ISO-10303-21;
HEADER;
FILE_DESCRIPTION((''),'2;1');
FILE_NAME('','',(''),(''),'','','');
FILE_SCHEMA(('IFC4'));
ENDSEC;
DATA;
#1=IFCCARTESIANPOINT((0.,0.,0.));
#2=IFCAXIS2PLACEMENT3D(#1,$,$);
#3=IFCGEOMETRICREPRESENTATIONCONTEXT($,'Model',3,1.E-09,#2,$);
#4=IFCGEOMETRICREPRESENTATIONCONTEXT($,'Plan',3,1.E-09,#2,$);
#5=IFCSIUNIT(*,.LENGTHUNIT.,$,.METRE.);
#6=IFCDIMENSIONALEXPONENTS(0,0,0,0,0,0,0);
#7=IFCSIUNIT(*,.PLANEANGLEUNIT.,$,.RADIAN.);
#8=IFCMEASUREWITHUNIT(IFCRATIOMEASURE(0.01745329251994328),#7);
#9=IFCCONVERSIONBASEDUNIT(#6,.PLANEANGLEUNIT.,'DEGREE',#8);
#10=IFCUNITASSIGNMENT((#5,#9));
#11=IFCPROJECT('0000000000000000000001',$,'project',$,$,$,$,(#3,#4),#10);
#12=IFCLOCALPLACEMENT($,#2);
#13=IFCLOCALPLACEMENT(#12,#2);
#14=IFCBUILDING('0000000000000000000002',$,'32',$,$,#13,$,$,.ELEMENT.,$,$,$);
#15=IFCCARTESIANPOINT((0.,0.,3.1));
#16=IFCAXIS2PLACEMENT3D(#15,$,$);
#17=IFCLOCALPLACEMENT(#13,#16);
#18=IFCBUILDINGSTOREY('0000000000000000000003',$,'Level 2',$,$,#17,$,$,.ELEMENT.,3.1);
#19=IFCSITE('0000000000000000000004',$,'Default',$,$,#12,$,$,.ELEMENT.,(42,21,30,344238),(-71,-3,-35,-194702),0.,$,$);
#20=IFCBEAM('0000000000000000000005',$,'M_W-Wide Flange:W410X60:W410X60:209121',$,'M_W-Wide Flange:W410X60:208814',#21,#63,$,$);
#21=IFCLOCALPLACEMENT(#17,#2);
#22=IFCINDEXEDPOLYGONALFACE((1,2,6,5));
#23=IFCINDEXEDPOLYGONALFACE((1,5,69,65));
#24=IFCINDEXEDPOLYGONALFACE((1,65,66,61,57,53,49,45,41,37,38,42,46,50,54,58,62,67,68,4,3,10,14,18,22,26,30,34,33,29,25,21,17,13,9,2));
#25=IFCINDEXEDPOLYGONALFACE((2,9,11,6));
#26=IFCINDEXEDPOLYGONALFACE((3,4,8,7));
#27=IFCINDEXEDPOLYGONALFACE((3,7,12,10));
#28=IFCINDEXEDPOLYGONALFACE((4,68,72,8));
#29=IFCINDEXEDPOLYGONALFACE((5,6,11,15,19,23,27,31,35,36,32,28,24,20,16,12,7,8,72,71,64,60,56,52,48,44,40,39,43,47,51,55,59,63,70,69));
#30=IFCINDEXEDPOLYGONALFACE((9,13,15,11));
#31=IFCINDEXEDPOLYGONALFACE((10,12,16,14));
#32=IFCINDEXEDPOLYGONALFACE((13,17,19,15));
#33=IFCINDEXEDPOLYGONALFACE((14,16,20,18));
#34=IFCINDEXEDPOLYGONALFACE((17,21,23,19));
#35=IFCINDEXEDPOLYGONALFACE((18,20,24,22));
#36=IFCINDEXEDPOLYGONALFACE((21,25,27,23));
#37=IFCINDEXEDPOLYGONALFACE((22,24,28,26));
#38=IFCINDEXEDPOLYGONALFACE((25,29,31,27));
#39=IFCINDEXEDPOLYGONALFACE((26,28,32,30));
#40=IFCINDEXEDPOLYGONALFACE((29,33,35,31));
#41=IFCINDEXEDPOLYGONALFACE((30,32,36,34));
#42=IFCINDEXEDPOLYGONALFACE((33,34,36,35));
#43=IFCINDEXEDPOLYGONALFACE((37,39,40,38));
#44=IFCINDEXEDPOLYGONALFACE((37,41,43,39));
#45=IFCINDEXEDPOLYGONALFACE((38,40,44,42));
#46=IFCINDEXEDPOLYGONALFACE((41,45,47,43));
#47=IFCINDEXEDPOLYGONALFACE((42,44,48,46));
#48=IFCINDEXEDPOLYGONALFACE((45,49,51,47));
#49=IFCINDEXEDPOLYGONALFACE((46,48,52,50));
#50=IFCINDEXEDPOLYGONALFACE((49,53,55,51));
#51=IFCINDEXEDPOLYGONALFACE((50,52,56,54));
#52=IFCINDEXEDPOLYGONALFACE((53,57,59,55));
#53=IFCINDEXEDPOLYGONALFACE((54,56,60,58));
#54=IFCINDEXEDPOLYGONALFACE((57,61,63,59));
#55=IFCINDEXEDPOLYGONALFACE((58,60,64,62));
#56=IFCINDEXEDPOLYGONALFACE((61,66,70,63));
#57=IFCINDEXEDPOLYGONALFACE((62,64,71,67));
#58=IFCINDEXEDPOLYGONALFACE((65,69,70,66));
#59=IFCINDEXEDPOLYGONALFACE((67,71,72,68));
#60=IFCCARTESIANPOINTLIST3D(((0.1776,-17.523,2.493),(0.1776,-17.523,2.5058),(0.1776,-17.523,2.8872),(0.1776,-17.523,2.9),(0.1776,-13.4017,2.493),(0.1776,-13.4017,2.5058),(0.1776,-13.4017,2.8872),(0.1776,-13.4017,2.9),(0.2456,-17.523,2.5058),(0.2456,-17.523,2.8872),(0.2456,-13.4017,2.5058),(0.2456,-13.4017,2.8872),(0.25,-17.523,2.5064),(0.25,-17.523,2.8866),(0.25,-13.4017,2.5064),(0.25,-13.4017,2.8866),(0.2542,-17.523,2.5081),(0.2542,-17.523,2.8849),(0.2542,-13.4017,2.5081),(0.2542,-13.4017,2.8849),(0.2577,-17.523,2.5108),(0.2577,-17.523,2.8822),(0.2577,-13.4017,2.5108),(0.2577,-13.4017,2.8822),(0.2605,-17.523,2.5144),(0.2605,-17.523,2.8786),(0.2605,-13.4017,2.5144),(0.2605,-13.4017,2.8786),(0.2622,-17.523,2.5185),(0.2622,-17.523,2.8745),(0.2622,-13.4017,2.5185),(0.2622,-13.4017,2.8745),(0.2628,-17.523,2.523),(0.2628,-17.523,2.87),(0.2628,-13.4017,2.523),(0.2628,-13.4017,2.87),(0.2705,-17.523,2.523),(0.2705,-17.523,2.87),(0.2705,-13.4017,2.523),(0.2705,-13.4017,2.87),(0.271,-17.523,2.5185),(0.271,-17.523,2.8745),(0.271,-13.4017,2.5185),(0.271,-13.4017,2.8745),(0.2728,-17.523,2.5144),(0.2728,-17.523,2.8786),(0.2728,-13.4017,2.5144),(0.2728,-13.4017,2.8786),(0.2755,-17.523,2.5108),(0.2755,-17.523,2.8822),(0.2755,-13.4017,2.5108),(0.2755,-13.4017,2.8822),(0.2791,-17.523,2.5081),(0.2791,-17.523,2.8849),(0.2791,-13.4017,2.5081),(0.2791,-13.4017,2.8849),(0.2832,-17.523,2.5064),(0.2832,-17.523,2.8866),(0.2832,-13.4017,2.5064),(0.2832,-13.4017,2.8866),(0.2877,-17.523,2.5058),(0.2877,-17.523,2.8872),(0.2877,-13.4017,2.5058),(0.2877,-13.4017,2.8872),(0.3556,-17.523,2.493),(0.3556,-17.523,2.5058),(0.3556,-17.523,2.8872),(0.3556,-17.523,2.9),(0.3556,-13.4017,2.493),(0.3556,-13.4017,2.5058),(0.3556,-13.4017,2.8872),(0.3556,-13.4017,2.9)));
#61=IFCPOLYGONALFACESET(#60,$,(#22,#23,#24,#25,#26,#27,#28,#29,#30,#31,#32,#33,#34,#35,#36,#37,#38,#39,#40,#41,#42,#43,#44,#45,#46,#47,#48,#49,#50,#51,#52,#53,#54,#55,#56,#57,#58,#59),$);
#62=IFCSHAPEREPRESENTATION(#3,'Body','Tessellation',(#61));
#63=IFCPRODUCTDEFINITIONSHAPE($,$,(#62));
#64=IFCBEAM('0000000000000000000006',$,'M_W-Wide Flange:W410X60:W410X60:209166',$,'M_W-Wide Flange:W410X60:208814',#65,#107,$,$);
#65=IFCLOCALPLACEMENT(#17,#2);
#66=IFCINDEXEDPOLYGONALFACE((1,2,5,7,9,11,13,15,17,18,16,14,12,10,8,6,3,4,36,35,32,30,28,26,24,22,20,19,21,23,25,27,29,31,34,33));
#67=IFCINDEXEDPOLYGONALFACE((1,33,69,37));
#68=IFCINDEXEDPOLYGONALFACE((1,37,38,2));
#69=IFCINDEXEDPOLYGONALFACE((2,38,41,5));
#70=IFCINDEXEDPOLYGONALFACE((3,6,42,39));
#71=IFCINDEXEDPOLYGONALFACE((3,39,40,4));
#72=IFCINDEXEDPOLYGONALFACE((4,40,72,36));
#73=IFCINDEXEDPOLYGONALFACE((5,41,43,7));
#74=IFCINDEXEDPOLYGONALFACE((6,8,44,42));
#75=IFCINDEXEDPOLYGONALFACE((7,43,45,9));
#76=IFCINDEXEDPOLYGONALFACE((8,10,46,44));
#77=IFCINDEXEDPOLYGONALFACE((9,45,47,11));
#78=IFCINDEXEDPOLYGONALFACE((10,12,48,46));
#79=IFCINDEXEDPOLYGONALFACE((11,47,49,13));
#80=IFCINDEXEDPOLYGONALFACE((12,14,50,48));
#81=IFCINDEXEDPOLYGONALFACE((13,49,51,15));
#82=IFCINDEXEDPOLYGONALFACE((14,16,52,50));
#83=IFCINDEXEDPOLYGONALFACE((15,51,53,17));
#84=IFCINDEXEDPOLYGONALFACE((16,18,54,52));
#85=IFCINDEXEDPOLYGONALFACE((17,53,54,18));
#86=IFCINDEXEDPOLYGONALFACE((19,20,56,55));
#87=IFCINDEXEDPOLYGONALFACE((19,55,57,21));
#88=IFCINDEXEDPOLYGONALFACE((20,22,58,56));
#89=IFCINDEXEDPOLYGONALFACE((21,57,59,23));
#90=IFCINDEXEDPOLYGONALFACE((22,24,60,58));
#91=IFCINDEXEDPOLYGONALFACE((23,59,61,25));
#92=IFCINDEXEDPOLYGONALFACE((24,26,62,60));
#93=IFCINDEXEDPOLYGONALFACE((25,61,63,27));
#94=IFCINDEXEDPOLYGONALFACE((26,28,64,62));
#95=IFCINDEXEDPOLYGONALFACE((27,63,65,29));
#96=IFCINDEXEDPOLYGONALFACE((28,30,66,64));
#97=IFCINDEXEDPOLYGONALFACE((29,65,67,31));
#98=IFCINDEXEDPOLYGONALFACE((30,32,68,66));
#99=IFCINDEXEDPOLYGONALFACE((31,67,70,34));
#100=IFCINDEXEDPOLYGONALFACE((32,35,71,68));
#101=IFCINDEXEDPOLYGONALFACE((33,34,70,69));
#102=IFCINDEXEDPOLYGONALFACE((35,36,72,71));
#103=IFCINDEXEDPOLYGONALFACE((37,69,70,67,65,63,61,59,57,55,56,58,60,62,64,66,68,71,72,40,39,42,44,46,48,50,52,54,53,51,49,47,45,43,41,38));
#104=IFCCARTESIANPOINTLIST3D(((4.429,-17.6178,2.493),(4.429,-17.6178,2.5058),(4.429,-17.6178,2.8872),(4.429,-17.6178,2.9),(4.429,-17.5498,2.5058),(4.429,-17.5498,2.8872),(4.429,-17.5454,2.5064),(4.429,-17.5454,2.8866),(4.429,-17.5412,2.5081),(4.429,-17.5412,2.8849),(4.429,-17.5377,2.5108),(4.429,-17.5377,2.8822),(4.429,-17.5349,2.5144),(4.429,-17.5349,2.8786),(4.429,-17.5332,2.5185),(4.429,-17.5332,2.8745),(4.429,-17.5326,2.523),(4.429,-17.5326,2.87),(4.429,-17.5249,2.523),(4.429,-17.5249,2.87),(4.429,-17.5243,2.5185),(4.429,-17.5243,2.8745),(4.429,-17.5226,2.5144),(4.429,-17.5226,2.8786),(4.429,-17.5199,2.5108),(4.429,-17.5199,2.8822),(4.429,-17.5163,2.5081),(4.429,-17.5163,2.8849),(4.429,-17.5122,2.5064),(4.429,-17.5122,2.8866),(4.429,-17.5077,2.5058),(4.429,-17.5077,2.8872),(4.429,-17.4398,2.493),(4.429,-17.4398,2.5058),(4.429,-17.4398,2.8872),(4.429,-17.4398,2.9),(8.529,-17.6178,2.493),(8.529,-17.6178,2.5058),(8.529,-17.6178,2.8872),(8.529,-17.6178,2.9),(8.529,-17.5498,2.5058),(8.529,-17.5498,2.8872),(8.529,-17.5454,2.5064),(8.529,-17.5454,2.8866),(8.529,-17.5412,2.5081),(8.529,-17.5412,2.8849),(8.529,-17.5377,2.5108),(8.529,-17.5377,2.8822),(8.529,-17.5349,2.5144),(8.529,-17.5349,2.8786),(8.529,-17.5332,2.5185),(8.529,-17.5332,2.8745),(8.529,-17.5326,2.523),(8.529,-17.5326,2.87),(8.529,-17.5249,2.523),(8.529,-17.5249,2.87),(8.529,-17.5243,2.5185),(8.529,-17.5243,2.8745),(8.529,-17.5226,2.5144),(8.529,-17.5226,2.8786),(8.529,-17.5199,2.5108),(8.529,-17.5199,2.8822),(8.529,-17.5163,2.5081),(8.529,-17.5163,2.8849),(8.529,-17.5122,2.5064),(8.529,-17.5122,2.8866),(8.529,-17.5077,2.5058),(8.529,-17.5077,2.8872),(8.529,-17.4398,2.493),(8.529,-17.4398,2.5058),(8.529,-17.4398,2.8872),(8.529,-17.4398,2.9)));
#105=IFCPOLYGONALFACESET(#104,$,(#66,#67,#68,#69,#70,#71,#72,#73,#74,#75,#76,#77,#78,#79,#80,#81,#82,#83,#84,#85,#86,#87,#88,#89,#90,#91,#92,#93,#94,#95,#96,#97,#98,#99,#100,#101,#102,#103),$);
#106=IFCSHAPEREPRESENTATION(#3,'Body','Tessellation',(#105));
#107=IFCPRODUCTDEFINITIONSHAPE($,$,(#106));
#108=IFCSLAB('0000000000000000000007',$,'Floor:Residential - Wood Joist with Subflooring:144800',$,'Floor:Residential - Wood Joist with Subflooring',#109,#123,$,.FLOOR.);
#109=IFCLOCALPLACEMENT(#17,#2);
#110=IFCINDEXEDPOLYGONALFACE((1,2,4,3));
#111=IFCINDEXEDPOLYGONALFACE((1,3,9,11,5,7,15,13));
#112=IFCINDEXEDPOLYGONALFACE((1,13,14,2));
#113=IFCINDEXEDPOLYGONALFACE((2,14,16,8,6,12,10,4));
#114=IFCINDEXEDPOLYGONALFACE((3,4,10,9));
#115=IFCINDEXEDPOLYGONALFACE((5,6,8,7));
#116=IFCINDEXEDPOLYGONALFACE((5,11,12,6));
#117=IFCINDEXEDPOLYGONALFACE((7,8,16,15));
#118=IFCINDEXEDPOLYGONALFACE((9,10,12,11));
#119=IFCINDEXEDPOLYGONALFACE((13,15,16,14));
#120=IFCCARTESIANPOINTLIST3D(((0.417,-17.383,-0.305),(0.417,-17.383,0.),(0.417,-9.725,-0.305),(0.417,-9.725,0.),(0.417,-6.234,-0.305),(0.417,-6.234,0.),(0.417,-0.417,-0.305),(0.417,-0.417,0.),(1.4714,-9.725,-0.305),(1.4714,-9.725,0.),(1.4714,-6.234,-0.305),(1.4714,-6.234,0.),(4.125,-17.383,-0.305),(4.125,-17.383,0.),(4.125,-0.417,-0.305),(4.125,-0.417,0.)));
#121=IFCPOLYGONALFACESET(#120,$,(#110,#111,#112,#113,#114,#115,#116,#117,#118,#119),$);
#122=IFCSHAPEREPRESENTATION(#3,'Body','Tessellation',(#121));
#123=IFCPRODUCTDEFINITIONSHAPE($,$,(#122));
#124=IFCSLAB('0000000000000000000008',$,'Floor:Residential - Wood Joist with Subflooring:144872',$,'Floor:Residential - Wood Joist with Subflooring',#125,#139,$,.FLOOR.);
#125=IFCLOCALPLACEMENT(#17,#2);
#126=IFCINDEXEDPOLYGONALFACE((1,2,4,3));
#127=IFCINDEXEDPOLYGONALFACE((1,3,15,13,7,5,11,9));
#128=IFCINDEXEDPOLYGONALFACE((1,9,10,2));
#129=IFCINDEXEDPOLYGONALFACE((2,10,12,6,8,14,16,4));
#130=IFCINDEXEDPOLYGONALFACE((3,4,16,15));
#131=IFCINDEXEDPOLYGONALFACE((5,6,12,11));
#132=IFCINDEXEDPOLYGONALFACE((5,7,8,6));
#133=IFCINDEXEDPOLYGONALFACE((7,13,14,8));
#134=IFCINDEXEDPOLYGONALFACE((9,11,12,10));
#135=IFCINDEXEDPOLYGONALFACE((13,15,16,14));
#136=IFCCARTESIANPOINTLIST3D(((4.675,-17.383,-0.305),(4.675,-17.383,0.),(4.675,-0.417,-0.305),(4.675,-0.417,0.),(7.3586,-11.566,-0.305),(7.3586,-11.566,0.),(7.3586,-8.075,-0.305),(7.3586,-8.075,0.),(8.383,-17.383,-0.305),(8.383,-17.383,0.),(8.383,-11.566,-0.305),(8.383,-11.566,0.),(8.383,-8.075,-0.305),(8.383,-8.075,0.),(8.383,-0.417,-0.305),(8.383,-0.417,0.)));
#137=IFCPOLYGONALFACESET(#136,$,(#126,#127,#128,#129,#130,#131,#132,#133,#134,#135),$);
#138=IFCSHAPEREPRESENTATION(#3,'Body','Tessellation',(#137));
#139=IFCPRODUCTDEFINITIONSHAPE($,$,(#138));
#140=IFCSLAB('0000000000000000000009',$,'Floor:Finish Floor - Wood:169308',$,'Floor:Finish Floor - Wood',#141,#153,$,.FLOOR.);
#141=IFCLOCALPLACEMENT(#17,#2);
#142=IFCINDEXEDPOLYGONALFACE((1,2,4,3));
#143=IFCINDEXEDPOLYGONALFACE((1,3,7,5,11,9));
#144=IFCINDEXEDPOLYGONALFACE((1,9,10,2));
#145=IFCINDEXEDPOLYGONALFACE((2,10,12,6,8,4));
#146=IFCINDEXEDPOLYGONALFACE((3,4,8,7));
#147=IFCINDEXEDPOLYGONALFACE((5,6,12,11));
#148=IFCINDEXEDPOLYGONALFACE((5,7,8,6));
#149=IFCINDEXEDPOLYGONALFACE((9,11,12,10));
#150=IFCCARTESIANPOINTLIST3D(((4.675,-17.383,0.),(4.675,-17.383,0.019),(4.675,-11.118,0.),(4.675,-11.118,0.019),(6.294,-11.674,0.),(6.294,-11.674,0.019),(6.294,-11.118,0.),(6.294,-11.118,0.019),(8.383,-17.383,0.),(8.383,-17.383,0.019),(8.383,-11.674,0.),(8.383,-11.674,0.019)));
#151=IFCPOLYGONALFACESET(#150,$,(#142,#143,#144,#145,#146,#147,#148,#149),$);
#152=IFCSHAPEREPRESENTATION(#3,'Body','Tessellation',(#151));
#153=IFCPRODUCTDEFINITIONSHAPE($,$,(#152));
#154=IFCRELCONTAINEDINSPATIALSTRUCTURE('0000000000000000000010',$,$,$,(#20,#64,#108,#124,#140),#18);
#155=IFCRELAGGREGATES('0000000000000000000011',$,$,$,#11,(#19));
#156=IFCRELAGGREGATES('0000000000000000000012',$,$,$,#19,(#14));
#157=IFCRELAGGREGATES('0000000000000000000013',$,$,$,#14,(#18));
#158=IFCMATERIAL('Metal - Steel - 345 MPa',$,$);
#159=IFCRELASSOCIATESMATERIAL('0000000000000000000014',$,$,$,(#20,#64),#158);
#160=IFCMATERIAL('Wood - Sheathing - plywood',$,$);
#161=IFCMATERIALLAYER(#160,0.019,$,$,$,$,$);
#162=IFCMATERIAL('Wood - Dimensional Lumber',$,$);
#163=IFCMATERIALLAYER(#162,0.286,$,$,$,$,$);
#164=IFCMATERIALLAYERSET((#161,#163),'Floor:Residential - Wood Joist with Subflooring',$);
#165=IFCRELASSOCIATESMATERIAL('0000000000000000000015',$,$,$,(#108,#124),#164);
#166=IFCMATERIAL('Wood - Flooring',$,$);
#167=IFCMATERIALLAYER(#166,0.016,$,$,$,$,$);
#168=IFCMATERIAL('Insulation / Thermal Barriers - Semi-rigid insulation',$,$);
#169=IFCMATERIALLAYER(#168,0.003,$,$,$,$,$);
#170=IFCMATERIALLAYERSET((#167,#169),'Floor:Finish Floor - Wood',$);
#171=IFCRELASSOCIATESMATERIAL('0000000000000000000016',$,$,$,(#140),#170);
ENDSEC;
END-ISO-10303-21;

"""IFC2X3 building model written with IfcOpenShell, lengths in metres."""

from ifc_helpers import new_model, entity, si_unit, converted_unit, frame, frame_2d, origin, place, context, project, spatial, polyline, circle_curve, parameter, trimmed, segment, composite_curve, outline, extrude, material, layer, layer_set, layer_usage, element, save


model = new_model("IFC2X3")

# Units and contexts
model_context = context("Model", 3, precision=1e-09, world=origin())
plan_context = context("Plan", 3, precision=1e-09, world=origin())
ifc_project = project(units=[si_unit("LENGTHUNIT", "METRE"), converted_unit("PLANEANGLEUNIT", "DEGREE", entity("IfcRatioMeasure", 0.01745329251994328), si_unit("PLANEANGLEUNIT", "RADIAN"), dimensions=[0, 0, 0, 0, 0, 0, 0])], contexts=[model_context, plan_context])

# Site, building, storey
site_placement = place(None, origin())
site = spatial("IfcSite", under=ifc_project, at=site_placement, Name="Default", CompositionType="ELEMENT", RefLatitude=(42, 21, 30, 344238), RefLongitude=(-71, -3, -35, -194702), RefElevation=0.0)
building_placement = place(site_placement, origin())
building = spatial("IfcBuilding", under=site, at=building_placement, Name="32", CompositionType="ELEMENT")
storey_placement = place(building_placement, frame((0.0, 0.0, 3.1)))
storey = spatial("IfcBuildingStorey", under=building, at=storey_placement, Name="Level 2", CompositionType="ELEMENT", Elevation=3.1)

# Beams
ifc_material_1 = material(Name="Metal - Steel - 345 MPa")
beam_1_placement = place(storey_placement, frame((0.2666, -13.4017, 2.9), z_axis=(0.0, 0.0, 1.0), x_axis=(-1.0, 0.0, 0.0)))
element("IfcBeam", 1, at=beam_1_placement, inside=storey, material=ifc_material_1, Name="M_W-Wide Flange:W410X60:W410X60:209121", ObjectType="M_W-Wide Flange:W410X60:208814", context=model_context, shape_type="SweptSolid", body=[
    extrude(outline(composite_curve([segment(polyline([(0.1907, -0.089), (0.2035, -0.089)]), True, "CONTINUOUS"), segment(polyline([(0.2035, -0.089), (0.2035, 0.089)]), True, "CONTINUOUS"), segment(polyline([(0.2035, 0.089), (0.1907, 0.089)]), True, "CONTINUOUS"), segment(polyline([(0.1907, 0.089), (0.1907, 0.021)]), True, "CONTINUOUS"), segment(trimmed(circle_curve(frame_2d((0.1735, 0.021), x_axis=(1.0, 0.0)), 0.0172), [parameter(270.0)], [parameter(360.0)], True, "PARAMETER"), False, "CONTINUOUS"), segment(polyline([(0.1735, 0.0038), (-0.1735, 0.0038)]), True, "CONTINUOUS"), segment(trimmed(circle_curve(frame_2d((-0.1735, 0.021), x_axis=(0.0, -1.0)), 0.0172), [parameter(270.0)], [parameter(360.0)], True, "PARAMETER"), False, "CONTINUOUS"), segment(polyline([(-0.1907, 0.021), (-0.1907, 0.089)]), True, "CONTINUOUS"), segment(polyline([(-0.1907, 0.089), (-0.2035, 0.089)]), True, "CONTINUOUS"), segment(polyline([(-0.2035, 0.089), (-0.2035, -0.089)]), True, "CONTINUOUS"), segment(polyline([(-0.2035, -0.089), (-0.1907, -0.089)]), True, "CONTINUOUS"), segment(polyline([(-0.1907, -0.089), (-0.1907, -0.0211)]), True, "CONTINUOUS"), segment(trimmed(circle_curve(frame_2d((-0.1735, -0.0211), x_axis=(-1.0, 0.0)), 0.0172), [parameter(270.0)], [parameter(0.0)], True, "PARAMETER"), False, "CONTINUOUS"), segment(polyline([(-0.1735, -0.0039), (0.1735, -0.0039)]), True, "CONTINUOUS"), segment(trimmed(circle_curve(frame_2d((0.1735, -0.0211), x_axis=(0.0, 1.0)), 0.0172), [parameter(270.0)], [parameter(0.0)], True, "PARAMETER"), False, "CONTINUOUS"), segment(polyline([(0.1907, -0.0211), (0.1907, -0.089)]), True, "CONTINUOUS")], self_intersect=False)), frame((0.0, 4.1213, -0.2035), z_axis=(0.0, -1.0, 0.0), x_axis=(0.0, 0.0, -1.0)), (0.0, 0.0, 1.0), 4.1213),
])
beam_2_placement = place(storey_placement, frame((4.429, -17.5288, 2.9), z_axis=(0.0, 0.0, 1.0), x_axis=(0.0, -1.0, 0.0)))
element("IfcBeam", 2, at=beam_2_placement, inside=storey, material=ifc_material_1, Name="M_W-Wide Flange:W410X60:W410X60:209166", ObjectType="M_W-Wide Flange:W410X60:208814", context=model_context, shape_type="SweptSolid", body=[
    extrude(outline(composite_curve([segment(polyline([(-0.089, -0.1907), (-0.089, -0.2035)]), True, "CONTINUOUS"), segment(polyline([(-0.089, -0.2035), (0.089, -0.2035)]), True, "CONTINUOUS"), segment(polyline([(0.089, -0.2035), (0.089, -0.1907)]), True, "CONTINUOUS"), segment(polyline([(0.089, -0.1907), (0.021, -0.1907)]), True, "CONTINUOUS"), segment(trimmed(circle_curve(frame_2d((0.021, -0.1735), x_axis=(0.0, -1.0)), 0.0172), [parameter(270.0)], [parameter(360.0)], True, "PARAMETER"), False, "CONTINUOUS"), segment(polyline([(0.0038, -0.1735), (0.0038, 0.1735)]), True, "CONTINUOUS"), segment(trimmed(circle_curve(frame_2d((0.021, 0.1735), x_axis=(-1.0, 0.0)), 0.0172), [parameter(270.0)], [parameter(360.0)], True, "PARAMETER"), False, "CONTINUOUS"), segment(polyline([(0.021, 0.1907), (0.089, 0.1907)]), True, "CONTINUOUS"), segment(polyline([(0.089, 0.1907), (0.089, 0.2035)]), True, "CONTINUOUS"), segment(polyline([(0.089, 0.2035), (-0.089, 0.2035)]), True, "CONTINUOUS"), segment(polyline([(-0.089, 0.2035), (-0.089, 0.1907)]), True, "CONTINUOUS"), segment(polyline([(-0.089, 0.1907), (-0.0211, 0.1907)]), True, "CONTINUOUS"), segment(trimmed(circle_curve(frame_2d((-0.0211, 0.1735), x_axis=(0.0, 1.0)), 0.0172), [parameter(270.0)], [parameter(0.0)], True, "PARAMETER"), False, "CONTINUOUS"), segment(polyline([(-0.0039, 0.1735), (-0.0039, -0.1735)]), True, "CONTINUOUS"), segment(trimmed(circle_curve(frame_2d((-0.0211, -0.1735), x_axis=(1.0, 0.0)), 0.0172), [parameter(270.0)], [parameter(0.0)], True, "PARAMETER"), False, "CONTINUOUS"), segment(polyline([(-0.0211, -0.1907), (-0.089, -0.1907)]), True, "CONTINUOUS")], self_intersect=False)), frame((0.0, 0.0, -0.2035), z_axis=(0.0, -1.0, 0.0), x_axis=(1.0, 0.0, 0.0)), (0.0, 0.0, -1.0), 4.1),
])

# Slabs
ifc_material_2 = material(Name="Wood - Sheathing - plywood")
ifc_layer_1 = layer(ifc_material_2, 0.019)
ifc_material_3 = material(Name="Wood - Dimensional Lumber")
ifc_layer_2 = layer(ifc_material_3, 0.286)
ifc_layer_set_1 = layer_set([ifc_layer_1, ifc_layer_2], Name="Floor:Residential - Wood Joist with Subflooring")
ifc_layer_usage_1 = layer_usage(ifc_layer_set_1, "AXIS3", "POSITIVE", 0.0)
slab_1_placement = place(storey_placement, frame((0.417, -17.383, -0.305)))
element("IfcSlab", 3, at=slab_1_placement, inside=storey, material=ifc_layer_usage_1, Name="Floor:Residential - Wood Joist with Subflooring:144800", ObjectType="Floor:Residential - Wood Joist with Subflooring", PredefinedType="FLOOR", context=model_context, shape_type="SweptSolid", body=[
    extrude(outline(polyline([(-1.854, 8.483), (-1.854, -8.483), (1.854, -8.483), (1.854, -0.825), (0.7996, -0.825), (0.7996, 2.666), (1.854, 2.666), (1.854, 8.483), (-1.854, 8.483)])), frame((1.854, 8.483, 0.305), z_axis=(0.0, 0.0, -1.0), x_axis=(-1.0, 0.0, 0.0)), (0.0, 0.0, 1.0), 0.305),
])
ifc_layer_usage_2 = layer_usage(ifc_layer_set_1, "AXIS3", "POSITIVE", 0.0)
slab_2_placement = place(storey_placement, frame((4.675, -17.383, -0.305)))
element("IfcSlab", 4, at=slab_2_placement, inside=storey, material=ifc_layer_usage_2, Name="Floor:Residential - Wood Joist with Subflooring:144872", ObjectType="Floor:Residential - Wood Joist with Subflooring", PredefinedType="FLOOR", context=model_context, shape_type="SweptSolid", body=[
    extrude(outline(polyline([(-1.854, 8.483), (-1.854, 0.825), (-0.8296, 0.825), (-0.8296, -2.666), (-1.854, -2.666), (-1.854, -8.483), (1.854, -8.483), (1.854, 8.483), (-1.854, 8.483)])), frame((1.854, 8.483, 0.305), z_axis=(0.0, 0.0, -1.0), x_axis=(-1.0, 0.0, 0.0)), (0.0, 0.0, 1.0), 0.305),
])
ifc_material_4 = material(Name="Wood - Flooring")
ifc_layer_3 = layer(ifc_material_4, 0.016)
ifc_material_5 = material(Name="Insulation / Thermal Barriers - Semi-rigid insulation")
ifc_layer_4 = layer(ifc_material_5, 0.003)
ifc_layer_set_2 = layer_set([ifc_layer_3, ifc_layer_4], Name="Floor:Finish Floor - Wood")
ifc_layer_usage_3 = layer_usage(ifc_layer_set_2, "AXIS3", "POSITIVE", 0.0)
slab_3_placement = place(storey_placement, frame((4.675, -17.383, 0.0)))
element("IfcSlab", 5, at=slab_3_placement, inside=storey, material=ifc_layer_usage_3, Name="Floor:Finish Floor - Wood:169308", ObjectType="Floor:Finish Floor - Wood", PredefinedType="FLOOR", context=model_context, shape_type="SweptSolid", body=[
    extrude(outline(polyline([(-1.854, 2.5765), (-1.854, -3.1325), (1.854, -3.1325), (1.854, 3.1325), (0.235, 3.1325), (0.235, 2.5765), (-1.854, 2.5765)])), frame((1.854, 3.1325, 0.019), z_axis=(0.0, 0.0, -1.0), x_axis=(-1.0, 0.0, 0.0)), (0.0, 0.0, 1.0), 0.019),
])

save(model, "model.ifc")
